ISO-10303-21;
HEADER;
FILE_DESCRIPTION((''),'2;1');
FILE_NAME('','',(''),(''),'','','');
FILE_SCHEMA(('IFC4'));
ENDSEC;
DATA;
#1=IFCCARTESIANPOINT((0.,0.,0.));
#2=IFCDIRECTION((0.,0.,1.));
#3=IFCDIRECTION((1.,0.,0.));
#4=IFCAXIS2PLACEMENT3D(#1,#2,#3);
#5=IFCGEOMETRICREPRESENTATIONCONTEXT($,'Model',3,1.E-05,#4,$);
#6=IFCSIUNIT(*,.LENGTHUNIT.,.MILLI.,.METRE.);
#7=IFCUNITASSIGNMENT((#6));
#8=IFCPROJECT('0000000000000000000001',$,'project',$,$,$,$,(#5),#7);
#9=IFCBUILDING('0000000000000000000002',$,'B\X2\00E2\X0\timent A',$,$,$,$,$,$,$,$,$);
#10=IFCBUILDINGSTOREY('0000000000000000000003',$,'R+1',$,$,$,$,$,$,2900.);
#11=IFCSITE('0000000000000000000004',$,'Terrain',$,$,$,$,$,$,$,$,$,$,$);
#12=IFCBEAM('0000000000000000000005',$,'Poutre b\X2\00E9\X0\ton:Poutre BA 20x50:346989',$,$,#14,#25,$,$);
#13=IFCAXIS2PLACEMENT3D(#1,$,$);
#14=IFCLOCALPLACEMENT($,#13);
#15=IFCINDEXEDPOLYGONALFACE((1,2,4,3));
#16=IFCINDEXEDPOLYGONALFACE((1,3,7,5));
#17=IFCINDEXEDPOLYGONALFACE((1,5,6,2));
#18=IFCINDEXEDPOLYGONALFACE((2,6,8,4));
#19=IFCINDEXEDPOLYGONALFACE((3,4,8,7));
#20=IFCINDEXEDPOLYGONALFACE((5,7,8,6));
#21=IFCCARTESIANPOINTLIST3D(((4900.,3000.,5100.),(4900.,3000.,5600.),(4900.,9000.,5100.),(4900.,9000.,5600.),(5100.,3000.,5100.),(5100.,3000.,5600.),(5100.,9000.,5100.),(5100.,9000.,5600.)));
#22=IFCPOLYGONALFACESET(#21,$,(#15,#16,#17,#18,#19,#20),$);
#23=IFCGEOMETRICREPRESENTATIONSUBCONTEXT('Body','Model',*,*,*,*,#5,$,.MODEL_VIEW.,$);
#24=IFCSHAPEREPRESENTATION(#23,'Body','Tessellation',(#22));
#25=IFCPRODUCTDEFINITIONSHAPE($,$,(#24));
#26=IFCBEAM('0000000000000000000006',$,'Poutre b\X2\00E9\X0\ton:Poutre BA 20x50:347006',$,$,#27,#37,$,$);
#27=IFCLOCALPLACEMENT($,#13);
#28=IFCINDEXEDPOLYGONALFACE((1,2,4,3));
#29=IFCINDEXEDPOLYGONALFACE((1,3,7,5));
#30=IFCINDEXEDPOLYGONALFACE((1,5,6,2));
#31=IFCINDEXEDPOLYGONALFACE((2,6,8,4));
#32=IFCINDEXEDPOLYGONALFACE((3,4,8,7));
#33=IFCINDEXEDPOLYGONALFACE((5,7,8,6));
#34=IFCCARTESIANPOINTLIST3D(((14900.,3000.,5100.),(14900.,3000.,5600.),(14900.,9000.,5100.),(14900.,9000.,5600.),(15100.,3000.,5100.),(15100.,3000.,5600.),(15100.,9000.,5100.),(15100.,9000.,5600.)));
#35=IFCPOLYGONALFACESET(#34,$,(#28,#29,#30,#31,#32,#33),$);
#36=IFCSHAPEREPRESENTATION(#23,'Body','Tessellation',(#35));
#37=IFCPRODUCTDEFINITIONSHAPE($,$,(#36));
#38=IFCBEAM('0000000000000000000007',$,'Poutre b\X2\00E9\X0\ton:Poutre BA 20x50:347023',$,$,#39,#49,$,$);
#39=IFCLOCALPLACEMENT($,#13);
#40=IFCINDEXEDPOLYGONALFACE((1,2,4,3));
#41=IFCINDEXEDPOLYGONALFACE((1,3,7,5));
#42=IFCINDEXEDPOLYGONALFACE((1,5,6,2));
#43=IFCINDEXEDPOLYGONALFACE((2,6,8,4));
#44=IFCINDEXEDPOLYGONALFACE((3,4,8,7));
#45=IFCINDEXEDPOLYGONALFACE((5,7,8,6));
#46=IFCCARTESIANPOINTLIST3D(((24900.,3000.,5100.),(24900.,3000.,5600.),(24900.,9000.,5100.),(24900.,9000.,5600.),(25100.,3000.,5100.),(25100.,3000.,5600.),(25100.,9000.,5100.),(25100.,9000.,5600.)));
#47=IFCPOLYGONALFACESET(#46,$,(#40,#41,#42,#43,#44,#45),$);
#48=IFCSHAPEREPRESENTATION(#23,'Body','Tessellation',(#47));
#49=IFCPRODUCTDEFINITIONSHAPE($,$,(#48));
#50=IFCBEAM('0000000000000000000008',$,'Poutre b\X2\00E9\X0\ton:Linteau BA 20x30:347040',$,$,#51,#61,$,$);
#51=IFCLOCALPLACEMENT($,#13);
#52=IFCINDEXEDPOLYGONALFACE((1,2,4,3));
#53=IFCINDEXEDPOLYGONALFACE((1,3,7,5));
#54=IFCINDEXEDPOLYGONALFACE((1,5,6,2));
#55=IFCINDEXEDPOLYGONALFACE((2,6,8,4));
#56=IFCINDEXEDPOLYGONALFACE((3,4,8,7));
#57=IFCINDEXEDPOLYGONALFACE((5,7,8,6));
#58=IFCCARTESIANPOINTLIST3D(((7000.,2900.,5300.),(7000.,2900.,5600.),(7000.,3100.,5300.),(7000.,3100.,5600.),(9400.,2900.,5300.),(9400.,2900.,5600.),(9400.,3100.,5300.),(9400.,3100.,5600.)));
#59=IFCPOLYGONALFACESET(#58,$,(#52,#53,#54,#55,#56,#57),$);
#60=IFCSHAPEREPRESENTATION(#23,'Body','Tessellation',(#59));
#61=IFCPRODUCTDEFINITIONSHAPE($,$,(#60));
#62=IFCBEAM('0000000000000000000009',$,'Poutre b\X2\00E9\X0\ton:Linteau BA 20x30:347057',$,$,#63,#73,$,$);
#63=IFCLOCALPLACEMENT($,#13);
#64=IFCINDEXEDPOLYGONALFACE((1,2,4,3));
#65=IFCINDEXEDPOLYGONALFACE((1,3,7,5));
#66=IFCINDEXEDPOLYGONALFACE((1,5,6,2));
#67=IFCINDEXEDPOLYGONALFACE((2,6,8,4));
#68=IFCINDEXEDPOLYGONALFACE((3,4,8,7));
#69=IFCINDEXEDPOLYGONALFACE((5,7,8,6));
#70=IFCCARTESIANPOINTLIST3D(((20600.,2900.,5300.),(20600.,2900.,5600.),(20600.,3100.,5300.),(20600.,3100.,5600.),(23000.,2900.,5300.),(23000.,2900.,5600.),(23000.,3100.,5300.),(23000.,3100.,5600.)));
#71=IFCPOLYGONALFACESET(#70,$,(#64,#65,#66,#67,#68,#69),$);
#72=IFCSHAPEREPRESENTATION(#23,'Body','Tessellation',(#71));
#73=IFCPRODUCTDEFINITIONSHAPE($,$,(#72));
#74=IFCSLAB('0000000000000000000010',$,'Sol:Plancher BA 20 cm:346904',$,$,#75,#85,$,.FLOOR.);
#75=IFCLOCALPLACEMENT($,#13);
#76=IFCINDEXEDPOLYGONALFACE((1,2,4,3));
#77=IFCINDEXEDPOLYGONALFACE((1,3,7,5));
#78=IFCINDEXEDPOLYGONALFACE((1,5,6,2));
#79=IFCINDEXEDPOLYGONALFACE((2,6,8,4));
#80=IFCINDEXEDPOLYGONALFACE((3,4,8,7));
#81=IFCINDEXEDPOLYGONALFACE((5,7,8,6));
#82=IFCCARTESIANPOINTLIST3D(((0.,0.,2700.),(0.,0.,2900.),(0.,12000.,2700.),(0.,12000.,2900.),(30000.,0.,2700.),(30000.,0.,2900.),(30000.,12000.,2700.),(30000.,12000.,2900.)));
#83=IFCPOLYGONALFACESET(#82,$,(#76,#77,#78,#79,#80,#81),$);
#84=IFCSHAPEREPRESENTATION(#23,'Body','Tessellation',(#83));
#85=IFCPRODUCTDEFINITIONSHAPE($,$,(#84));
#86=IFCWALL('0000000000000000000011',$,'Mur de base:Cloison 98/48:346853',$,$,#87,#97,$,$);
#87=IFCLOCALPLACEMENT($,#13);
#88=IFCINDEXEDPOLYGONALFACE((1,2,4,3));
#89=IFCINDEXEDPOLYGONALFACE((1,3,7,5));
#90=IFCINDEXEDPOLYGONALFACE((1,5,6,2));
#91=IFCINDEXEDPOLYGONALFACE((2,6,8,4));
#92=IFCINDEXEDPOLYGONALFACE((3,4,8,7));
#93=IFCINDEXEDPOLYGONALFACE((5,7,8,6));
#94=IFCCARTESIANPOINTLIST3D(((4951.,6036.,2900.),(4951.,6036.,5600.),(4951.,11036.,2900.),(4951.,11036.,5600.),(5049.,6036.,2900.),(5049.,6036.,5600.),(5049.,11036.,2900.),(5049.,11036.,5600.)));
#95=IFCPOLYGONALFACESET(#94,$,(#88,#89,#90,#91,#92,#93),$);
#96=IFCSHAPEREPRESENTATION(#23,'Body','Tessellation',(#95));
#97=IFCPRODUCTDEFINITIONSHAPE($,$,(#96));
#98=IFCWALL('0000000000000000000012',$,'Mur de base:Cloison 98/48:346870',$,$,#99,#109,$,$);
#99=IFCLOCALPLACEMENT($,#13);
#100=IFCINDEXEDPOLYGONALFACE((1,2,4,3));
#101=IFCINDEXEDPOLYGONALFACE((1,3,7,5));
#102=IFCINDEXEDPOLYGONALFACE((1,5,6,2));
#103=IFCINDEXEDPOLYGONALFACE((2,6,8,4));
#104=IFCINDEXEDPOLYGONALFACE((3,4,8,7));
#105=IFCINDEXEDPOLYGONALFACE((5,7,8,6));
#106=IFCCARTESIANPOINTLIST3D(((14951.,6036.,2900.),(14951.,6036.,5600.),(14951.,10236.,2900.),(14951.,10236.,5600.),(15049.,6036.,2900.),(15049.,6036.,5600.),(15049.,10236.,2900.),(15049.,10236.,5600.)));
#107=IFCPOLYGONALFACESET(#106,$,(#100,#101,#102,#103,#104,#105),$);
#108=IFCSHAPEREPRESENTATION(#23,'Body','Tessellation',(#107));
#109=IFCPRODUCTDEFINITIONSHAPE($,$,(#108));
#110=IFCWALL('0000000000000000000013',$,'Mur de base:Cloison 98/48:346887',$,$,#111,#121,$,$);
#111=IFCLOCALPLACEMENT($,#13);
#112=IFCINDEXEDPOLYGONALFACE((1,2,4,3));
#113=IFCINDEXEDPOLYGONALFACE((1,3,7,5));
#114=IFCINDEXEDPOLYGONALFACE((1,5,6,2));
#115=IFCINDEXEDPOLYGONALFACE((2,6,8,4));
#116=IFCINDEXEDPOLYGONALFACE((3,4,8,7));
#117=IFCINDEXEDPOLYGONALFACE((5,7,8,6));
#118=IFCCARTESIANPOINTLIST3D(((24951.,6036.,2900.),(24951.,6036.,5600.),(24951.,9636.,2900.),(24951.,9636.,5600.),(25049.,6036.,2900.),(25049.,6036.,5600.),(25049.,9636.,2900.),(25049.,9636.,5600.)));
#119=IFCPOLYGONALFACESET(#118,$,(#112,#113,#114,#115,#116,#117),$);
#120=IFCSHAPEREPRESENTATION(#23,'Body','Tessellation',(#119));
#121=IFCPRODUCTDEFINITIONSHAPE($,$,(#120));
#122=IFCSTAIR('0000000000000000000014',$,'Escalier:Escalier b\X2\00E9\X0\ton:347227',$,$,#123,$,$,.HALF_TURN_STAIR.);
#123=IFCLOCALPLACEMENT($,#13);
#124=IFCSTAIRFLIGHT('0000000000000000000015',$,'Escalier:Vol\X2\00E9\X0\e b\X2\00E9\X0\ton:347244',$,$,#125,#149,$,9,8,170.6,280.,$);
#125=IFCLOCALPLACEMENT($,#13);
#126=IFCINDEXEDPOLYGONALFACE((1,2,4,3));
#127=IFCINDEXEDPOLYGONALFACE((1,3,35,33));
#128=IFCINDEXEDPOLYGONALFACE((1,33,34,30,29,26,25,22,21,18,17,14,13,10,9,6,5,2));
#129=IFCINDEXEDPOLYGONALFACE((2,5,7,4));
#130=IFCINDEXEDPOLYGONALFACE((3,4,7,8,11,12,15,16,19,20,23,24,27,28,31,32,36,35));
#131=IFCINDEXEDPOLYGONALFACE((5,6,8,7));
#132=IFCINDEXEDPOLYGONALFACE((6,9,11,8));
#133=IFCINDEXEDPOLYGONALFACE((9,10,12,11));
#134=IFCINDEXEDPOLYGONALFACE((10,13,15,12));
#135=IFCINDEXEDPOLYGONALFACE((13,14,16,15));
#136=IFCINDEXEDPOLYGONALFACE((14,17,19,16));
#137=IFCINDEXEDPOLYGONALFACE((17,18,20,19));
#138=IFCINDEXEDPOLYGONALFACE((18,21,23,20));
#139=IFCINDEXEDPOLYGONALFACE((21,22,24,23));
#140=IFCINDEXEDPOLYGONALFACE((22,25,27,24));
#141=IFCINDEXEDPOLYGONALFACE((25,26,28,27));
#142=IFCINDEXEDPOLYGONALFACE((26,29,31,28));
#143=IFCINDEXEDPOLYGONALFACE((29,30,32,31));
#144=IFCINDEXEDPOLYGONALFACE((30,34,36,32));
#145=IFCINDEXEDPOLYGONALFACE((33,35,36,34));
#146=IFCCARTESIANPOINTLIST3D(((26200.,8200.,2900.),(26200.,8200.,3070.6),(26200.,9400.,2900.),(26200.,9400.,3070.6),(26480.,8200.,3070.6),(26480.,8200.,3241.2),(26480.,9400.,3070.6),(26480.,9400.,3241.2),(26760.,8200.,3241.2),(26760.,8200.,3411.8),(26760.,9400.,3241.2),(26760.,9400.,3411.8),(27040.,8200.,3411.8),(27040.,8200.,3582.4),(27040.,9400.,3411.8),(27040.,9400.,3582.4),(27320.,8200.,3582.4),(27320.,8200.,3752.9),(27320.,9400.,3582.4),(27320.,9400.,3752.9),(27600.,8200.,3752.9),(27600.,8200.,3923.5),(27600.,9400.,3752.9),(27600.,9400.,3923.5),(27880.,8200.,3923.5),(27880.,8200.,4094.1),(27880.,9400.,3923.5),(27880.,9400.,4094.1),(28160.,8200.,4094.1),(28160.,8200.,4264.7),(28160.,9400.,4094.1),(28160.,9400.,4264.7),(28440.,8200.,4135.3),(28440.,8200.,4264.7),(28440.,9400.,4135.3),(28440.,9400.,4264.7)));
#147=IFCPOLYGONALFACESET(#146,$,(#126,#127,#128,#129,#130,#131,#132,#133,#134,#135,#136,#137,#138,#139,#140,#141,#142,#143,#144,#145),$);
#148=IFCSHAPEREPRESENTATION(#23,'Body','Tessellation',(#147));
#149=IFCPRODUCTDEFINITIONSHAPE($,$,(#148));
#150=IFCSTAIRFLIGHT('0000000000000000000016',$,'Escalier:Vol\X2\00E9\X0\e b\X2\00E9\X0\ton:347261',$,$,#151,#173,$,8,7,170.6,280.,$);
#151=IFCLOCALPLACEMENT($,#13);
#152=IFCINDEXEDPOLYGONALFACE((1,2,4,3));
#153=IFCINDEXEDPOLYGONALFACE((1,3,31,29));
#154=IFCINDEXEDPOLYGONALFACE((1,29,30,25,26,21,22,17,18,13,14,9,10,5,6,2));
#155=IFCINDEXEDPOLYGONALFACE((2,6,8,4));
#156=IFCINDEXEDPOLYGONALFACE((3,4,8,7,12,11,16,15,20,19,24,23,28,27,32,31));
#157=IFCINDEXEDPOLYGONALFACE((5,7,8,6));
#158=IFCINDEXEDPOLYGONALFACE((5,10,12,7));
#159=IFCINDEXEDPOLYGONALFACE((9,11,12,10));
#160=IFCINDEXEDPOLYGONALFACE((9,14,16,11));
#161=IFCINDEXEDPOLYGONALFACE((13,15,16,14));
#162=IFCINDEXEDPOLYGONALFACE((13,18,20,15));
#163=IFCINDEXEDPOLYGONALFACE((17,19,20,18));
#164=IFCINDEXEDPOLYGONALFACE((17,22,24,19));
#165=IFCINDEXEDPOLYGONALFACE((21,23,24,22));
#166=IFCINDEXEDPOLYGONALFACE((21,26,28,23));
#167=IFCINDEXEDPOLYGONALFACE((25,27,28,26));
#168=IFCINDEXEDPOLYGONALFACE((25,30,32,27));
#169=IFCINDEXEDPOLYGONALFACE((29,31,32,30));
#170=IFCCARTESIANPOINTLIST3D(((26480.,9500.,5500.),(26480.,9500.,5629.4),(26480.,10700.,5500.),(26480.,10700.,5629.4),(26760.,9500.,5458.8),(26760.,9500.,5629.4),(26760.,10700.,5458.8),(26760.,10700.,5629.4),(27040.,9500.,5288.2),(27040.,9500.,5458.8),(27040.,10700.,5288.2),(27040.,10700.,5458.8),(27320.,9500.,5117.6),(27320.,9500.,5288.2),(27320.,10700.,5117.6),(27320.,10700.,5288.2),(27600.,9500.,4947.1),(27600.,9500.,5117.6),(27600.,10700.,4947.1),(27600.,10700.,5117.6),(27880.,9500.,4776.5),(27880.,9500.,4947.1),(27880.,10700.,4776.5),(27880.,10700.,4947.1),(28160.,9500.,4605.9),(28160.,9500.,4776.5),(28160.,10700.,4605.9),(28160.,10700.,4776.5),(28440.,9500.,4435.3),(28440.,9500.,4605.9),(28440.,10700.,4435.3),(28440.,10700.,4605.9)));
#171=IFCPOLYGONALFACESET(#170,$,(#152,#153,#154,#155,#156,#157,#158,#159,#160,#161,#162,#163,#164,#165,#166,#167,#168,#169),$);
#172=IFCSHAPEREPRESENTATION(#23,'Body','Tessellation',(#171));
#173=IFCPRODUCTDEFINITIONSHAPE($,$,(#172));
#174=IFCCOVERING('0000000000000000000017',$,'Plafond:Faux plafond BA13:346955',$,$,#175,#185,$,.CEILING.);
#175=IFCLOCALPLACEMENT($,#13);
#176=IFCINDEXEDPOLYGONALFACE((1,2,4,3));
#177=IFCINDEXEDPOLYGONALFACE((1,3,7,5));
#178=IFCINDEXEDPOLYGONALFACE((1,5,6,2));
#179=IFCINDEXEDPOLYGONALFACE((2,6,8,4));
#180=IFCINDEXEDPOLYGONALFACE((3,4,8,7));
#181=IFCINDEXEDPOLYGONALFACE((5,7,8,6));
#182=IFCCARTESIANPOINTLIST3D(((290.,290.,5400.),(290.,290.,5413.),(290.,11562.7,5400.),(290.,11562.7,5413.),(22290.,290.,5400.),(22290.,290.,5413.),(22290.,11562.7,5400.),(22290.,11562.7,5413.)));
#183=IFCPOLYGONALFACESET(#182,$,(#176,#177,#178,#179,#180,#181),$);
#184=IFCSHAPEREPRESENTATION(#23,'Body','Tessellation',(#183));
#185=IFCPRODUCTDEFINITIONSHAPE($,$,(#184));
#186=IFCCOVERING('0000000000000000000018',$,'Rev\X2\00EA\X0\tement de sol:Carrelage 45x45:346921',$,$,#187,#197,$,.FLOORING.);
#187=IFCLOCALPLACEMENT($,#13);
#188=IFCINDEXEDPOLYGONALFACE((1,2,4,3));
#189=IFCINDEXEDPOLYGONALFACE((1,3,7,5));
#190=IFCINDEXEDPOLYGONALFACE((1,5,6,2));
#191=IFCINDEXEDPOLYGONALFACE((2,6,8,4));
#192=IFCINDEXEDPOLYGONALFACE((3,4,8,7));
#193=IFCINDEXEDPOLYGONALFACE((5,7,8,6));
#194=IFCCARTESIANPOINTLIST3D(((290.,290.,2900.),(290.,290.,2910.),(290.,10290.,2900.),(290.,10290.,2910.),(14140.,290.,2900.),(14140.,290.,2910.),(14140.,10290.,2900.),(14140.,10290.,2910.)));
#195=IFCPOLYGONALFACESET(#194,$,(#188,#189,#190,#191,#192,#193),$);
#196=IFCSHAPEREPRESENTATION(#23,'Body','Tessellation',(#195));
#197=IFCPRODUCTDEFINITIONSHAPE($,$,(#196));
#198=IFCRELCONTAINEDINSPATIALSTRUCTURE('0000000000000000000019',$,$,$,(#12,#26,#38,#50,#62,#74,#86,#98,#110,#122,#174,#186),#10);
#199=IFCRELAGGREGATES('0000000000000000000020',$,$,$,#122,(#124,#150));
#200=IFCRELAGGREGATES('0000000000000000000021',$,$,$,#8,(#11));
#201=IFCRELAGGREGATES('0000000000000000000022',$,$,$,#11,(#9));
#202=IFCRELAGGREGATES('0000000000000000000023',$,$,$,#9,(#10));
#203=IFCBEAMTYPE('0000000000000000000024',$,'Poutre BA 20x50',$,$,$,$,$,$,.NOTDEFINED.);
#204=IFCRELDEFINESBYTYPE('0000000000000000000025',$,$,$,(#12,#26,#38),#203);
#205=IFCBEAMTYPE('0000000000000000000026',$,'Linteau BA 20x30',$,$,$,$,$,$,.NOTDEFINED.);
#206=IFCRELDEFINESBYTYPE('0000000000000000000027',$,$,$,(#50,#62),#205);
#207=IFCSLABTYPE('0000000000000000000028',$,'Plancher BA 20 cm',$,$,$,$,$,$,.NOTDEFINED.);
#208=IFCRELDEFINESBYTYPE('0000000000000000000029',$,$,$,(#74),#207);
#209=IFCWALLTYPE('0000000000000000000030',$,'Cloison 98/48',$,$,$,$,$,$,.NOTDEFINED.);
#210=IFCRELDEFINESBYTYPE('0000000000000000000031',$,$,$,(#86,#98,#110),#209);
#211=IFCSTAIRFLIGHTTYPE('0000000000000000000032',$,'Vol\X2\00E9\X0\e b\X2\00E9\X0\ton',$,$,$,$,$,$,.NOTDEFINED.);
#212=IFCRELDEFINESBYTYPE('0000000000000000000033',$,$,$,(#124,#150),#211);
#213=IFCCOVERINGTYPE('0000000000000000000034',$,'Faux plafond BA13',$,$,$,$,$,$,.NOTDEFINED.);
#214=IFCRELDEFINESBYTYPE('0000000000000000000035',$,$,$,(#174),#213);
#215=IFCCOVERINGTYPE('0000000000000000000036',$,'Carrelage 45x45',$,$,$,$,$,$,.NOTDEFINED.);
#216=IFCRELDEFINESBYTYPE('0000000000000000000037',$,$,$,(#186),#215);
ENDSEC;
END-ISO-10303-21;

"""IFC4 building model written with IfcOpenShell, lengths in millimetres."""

from ifc_helpers import new_model, si_unit, frame, frame_2d, origin_with_axes, place, context, subcontext, project, spatial, polyline, rectangle, outline, extrude, type_object, element, aggregate, save


model = new_model("IFC4")

# Units and contexts
model_context = context("Model", 3, precision=1e-05, world=origin_with_axes())
body_context = subcontext(model_context, "Body", "Model", "MODEL_VIEW")
ifc_project = project(units=[si_unit("LENGTHUNIT", "METRE", prefix="MILLI")], contexts=[model_context])

# Site, building, storey
site = spatial("IfcSite", under=ifc_project, Name="Terrain")
building = spatial("IfcBuilding", under=site, Name="Bâtiment A")
storey = spatial("IfcBuildingStorey", under=building, Name="R+1", Elevation=2900.0)

# Beams
beam_type_1 = type_object("IfcBeamType", Name="Poutre BA 20x50", PredefinedType="NOTDEFINED")
beam_1_placement = place(None, origin_with_axes())
element("IfcBeam", 1, at=beam_1_placement, inside=storey, type_object=beam_type_1, Name="Poutre béton:Poutre BA 20x50:346989", context=body_context, shape_type="SweptSolid", body=[
    extrude(rectangle(XDim=200.0, YDim=6000.0, at=frame_2d((5000.0, 6000.0))), frame((0.0, 0.0, 5100.0), z_axis=(0.0, 0.0, 1.0), x_axis=(1.0, 0.0, 0.0)), (0.0, 0.0, 1.0), 500.0),
])
beam_2_placement = place(None, origin_with_axes())
element("IfcBeam", 2, at=beam_2_placement, inside=storey, type_object=beam_type_1, Name="Poutre béton:Poutre BA 20x50:347006", context=body_context, shape_type="SweptSolid", body=[
    extrude(rectangle(XDim=200.0, YDim=6000.0, at=frame_2d((15000.0, 6000.0))), frame((0.0, 0.0, 5100.0), z_axis=(0.0, 0.0, 1.0), x_axis=(1.0, 0.0, 0.0)), (0.0, 0.0, 1.0), 500.0),
])
beam_3_placement = place(None, origin_with_axes())
element("IfcBeam", 3, at=beam_3_placement, inside=storey, type_object=beam_type_1, Name="Poutre béton:Poutre BA 20x50:347023", context=body_context, shape_type="SweptSolid", body=[
    extrude(rectangle(XDim=200.0, YDim=6000.0, at=frame_2d((25000.0, 6000.0))), frame((0.0, 0.0, 5100.0), z_axis=(0.0, 0.0, 1.0), x_axis=(1.0, 0.0, 0.0)), (0.0, 0.0, 1.0), 500.0),
])
beam_type_2 = type_object("IfcBeamType", Name="Linteau BA 20x30", PredefinedType="NOTDEFINED")
beam_4_placement = place(None, origin_with_axes())
element("IfcBeam", 4, at=beam_4_placement, inside=storey, type_object=beam_type_2, Name="Poutre béton:Linteau BA 20x30:347040", context=body_context, shape_type="SweptSolid", body=[
    extrude(rectangle(XDim=2400.0, YDim=200.0, at=frame_2d((8200.0, 3000.0))), frame((0.0, 0.0, 5300.0), z_axis=(0.0, 0.0, 1.0), x_axis=(1.0, 0.0, 0.0)), (0.0, 0.0, 1.0), 300.0),
])
beam_5_placement = place(None, origin_with_axes())
element("IfcBeam", 5, at=beam_5_placement, inside=storey, type_object=beam_type_2, Name="Poutre béton:Linteau BA 20x30:347057", context=body_context, shape_type="SweptSolid", body=[
    extrude(rectangle(XDim=2400.0, YDim=200.0, at=frame_2d((21800.0, 3000.0))), frame((0.0, 0.0, 5300.0), z_axis=(0.0, 0.0, 1.0), x_axis=(1.0, 0.0, 0.0)), (0.0, 0.0, 1.0), 300.0),
])

# Slab
slab_type = type_object("IfcSlabType", Name="Plancher BA 20 cm", PredefinedType="NOTDEFINED")
slab_placement = place(None, origin_with_axes())
element("IfcSlab", 6, at=slab_placement, inside=storey, type_object=slab_type, Name="Sol:Plancher BA 20 cm:346904", PredefinedType="FLOOR", context=body_context, shape_type="SweptSolid", body=[
    extrude(rectangle(XDim=30000.0, YDim=12000.0, at=frame_2d((15000.0, 6000.0))), frame((0.0, 0.0, 2700.0), z_axis=(0.0, 0.0, 1.0), x_axis=(1.0, 0.0, 0.0)), (0.0, 0.0, 1.0), 200.0),
])

# Walls
wall_type = type_object("IfcWallType", Name="Cloison 98/48", PredefinedType="NOTDEFINED")
wall_1_placement = place(None, origin_with_axes())
element("IfcWall", 7, at=wall_1_placement, inside=storey, type_object=wall_type, Name="Mur de base:Cloison 98/48:346853", context=body_context, shape_type="SweptSolid", body=[
    extrude(rectangle(XDim=98.0, YDim=5000.0, at=frame_2d((5000.0, 8536.0))), frame((0.0, 0.0, 2900.0), z_axis=(0.0, 0.0, 1.0), x_axis=(1.0, 0.0, 0.0)), (0.0, 0.0, 1.0), 2700.0),
])
wall_2_placement = place(None, origin_with_axes())
element("IfcWall", 8, at=wall_2_placement, inside=storey, type_object=wall_type, Name="Mur de base:Cloison 98/48:346870", context=body_context, shape_type="SweptSolid", body=[
    extrude(rectangle(XDim=98.0, YDim=4200.0, at=frame_2d((15000.0, 8136.0))), frame((0.0, 0.0, 2900.0), z_axis=(0.0, 0.0, 1.0), x_axis=(1.0, 0.0, 0.0)), (0.0, 0.0, 1.0), 2700.0),
])
wall_3_placement = place(None, origin_with_axes())
element("IfcWall", 9, at=wall_3_placement, inside=storey, type_object=wall_type, Name="Mur de base:Cloison 98/48:346887", context=body_context, shape_type="SweptSolid", body=[
    extrude(rectangle(XDim=98.0, YDim=3600.0, at=frame_2d((25000.0, 7836.0))), frame((0.0, 0.0, 2900.0), z_axis=(0.0, 0.0, 1.0), x_axis=(1.0, 0.0, 0.0)), (0.0, 0.0, 1.0), 2700.0),
])

# Stair, stair flights
stair = element("IfcStair", 10, inside=storey, Name="Escalier:Escalier béton:347227", PredefinedType="HALF_TURN_STAIR")
stair_flight_type = type_object("IfcStairFlightType", Name="Volée béton", PredefinedType="NOTDEFINED")
stair_flight_1_placement = place(None, origin_with_axes())
stair_flight_1 = element("IfcStairFlight", 11, at=stair_flight_1_placement, type_object=stair_flight_type, Name="Escalier:Volée béton:347244", NumberOfRisers=9, NumberOfTreads=8, RiserHeight=170.6, TreadLength=280.0, context=body_context, shape_type="SweptSolid", body=[
    extrude(outline(polyline([(0.0, 0.0), (0.0, 170.6), (280.0, 170.6), (280.0, 341.2), (560.0, 341.2), (560.0, 511.8), (840.0, 511.8), (840.0, 682.4), (1120.0, 682.4), (1120.0, 852.9), (1400.0, 852.9), (1400.0, 1023.5), (1680.0, 1023.5), (1680.0, 1194.1), (1960.0, 1194.1), (1960.0, 1364.7), (2240.0, 1364.7), (2240.0, 1535.3), (2240.0, 1235.3), (0.0, 0.0)])), frame((26200.0, 9400.0, 2900.0), z_axis=(0.0, -1.0, 0.0), x_axis=(1.0, 0.0, 0.0)), (0.0, 0.0, 1.0), 1200.0),
])
stair_flight_2_placement = place(None, origin_with_axes())
stair_flight_2 = element("IfcStairFlight", 12, at=stair_flight_2_placement, type_object=stair_flight_type, Name="Escalier:Volée béton:347261", NumberOfRisers=8, NumberOfTreads=7, RiserHeight=170.6, TreadLength=280.0, context=body_context, shape_type="SweptSolid", body=[
    extrude(outline(polyline([(0.0, 0.0), (0.0, 170.6), (280.0, 170.6), (280.0, 341.2), (560.0, 341.2), (560.0, 511.8), (840.0, 511.8), (840.0, 682.4), (1120.0, 682.4), (1120.0, 852.9), (1400.0, 852.9), (1400.0, 1023.5), (1680.0, 1023.5), (1680.0, 1194.1), (1960.0, 1194.1), (1960.0, 1364.7), (1960.0, 1064.7), (0.0, 0.0)])), frame((28440.0, 9500.0, 4435.3), z_axis=(0.0, 1.0, 0.0), x_axis=(-1.0, 0.0, 0.0)), (0.0, 0.0, 1.0), 1200.0),
])
aggregate(stair, [stair_flight_1, stair_flight_2])

# Coverings
covering_type_1 = type_object("IfcCoveringType", Name="Faux plafond BA13", PredefinedType="NOTDEFINED")
covering_1_placement = place(None, origin_with_axes())
element("IfcCovering", 13, at=covering_1_placement, inside=storey, type_object=covering_type_1, Name="Plafond:Faux plafond BA13:346955", PredefinedType="CEILING", context=body_context, shape_type="SweptSolid", body=[
    extrude(rectangle(XDim=22000.0, YDim=11272.7, at=frame_2d((11290.0, 5926.4))), frame((0.0, 0.0, 5400.0), z_axis=(0.0, 0.0, 1.0), x_axis=(1.0, 0.0, 0.0)), (0.0, 0.0, 1.0), 13.0),
])
covering_type_2 = type_object("IfcCoveringType", Name="Carrelage 45x45", PredefinedType="NOTDEFINED")
covering_2_placement = place(None, origin_with_axes())
element("IfcCovering", 14, at=covering_2_placement, inside=storey, type_object=covering_type_2, Name="Revêtement de sol:Carrelage 45x45:346921", PredefinedType="FLOORING", context=body_context, shape_type="SweptSolid", body=[
    extrude(rectangle(XDim=13850.0, YDim=10000.0, at=frame_2d((7215.0, 5290.0))), frame((0.0, 0.0, 2900.0), z_axis=(0.0, 0.0, 1.0), x_axis=(1.0, 0.0, 0.0)), (0.0, 0.0, 1.0), 10.0),
])

save(model, "model.ifc")
